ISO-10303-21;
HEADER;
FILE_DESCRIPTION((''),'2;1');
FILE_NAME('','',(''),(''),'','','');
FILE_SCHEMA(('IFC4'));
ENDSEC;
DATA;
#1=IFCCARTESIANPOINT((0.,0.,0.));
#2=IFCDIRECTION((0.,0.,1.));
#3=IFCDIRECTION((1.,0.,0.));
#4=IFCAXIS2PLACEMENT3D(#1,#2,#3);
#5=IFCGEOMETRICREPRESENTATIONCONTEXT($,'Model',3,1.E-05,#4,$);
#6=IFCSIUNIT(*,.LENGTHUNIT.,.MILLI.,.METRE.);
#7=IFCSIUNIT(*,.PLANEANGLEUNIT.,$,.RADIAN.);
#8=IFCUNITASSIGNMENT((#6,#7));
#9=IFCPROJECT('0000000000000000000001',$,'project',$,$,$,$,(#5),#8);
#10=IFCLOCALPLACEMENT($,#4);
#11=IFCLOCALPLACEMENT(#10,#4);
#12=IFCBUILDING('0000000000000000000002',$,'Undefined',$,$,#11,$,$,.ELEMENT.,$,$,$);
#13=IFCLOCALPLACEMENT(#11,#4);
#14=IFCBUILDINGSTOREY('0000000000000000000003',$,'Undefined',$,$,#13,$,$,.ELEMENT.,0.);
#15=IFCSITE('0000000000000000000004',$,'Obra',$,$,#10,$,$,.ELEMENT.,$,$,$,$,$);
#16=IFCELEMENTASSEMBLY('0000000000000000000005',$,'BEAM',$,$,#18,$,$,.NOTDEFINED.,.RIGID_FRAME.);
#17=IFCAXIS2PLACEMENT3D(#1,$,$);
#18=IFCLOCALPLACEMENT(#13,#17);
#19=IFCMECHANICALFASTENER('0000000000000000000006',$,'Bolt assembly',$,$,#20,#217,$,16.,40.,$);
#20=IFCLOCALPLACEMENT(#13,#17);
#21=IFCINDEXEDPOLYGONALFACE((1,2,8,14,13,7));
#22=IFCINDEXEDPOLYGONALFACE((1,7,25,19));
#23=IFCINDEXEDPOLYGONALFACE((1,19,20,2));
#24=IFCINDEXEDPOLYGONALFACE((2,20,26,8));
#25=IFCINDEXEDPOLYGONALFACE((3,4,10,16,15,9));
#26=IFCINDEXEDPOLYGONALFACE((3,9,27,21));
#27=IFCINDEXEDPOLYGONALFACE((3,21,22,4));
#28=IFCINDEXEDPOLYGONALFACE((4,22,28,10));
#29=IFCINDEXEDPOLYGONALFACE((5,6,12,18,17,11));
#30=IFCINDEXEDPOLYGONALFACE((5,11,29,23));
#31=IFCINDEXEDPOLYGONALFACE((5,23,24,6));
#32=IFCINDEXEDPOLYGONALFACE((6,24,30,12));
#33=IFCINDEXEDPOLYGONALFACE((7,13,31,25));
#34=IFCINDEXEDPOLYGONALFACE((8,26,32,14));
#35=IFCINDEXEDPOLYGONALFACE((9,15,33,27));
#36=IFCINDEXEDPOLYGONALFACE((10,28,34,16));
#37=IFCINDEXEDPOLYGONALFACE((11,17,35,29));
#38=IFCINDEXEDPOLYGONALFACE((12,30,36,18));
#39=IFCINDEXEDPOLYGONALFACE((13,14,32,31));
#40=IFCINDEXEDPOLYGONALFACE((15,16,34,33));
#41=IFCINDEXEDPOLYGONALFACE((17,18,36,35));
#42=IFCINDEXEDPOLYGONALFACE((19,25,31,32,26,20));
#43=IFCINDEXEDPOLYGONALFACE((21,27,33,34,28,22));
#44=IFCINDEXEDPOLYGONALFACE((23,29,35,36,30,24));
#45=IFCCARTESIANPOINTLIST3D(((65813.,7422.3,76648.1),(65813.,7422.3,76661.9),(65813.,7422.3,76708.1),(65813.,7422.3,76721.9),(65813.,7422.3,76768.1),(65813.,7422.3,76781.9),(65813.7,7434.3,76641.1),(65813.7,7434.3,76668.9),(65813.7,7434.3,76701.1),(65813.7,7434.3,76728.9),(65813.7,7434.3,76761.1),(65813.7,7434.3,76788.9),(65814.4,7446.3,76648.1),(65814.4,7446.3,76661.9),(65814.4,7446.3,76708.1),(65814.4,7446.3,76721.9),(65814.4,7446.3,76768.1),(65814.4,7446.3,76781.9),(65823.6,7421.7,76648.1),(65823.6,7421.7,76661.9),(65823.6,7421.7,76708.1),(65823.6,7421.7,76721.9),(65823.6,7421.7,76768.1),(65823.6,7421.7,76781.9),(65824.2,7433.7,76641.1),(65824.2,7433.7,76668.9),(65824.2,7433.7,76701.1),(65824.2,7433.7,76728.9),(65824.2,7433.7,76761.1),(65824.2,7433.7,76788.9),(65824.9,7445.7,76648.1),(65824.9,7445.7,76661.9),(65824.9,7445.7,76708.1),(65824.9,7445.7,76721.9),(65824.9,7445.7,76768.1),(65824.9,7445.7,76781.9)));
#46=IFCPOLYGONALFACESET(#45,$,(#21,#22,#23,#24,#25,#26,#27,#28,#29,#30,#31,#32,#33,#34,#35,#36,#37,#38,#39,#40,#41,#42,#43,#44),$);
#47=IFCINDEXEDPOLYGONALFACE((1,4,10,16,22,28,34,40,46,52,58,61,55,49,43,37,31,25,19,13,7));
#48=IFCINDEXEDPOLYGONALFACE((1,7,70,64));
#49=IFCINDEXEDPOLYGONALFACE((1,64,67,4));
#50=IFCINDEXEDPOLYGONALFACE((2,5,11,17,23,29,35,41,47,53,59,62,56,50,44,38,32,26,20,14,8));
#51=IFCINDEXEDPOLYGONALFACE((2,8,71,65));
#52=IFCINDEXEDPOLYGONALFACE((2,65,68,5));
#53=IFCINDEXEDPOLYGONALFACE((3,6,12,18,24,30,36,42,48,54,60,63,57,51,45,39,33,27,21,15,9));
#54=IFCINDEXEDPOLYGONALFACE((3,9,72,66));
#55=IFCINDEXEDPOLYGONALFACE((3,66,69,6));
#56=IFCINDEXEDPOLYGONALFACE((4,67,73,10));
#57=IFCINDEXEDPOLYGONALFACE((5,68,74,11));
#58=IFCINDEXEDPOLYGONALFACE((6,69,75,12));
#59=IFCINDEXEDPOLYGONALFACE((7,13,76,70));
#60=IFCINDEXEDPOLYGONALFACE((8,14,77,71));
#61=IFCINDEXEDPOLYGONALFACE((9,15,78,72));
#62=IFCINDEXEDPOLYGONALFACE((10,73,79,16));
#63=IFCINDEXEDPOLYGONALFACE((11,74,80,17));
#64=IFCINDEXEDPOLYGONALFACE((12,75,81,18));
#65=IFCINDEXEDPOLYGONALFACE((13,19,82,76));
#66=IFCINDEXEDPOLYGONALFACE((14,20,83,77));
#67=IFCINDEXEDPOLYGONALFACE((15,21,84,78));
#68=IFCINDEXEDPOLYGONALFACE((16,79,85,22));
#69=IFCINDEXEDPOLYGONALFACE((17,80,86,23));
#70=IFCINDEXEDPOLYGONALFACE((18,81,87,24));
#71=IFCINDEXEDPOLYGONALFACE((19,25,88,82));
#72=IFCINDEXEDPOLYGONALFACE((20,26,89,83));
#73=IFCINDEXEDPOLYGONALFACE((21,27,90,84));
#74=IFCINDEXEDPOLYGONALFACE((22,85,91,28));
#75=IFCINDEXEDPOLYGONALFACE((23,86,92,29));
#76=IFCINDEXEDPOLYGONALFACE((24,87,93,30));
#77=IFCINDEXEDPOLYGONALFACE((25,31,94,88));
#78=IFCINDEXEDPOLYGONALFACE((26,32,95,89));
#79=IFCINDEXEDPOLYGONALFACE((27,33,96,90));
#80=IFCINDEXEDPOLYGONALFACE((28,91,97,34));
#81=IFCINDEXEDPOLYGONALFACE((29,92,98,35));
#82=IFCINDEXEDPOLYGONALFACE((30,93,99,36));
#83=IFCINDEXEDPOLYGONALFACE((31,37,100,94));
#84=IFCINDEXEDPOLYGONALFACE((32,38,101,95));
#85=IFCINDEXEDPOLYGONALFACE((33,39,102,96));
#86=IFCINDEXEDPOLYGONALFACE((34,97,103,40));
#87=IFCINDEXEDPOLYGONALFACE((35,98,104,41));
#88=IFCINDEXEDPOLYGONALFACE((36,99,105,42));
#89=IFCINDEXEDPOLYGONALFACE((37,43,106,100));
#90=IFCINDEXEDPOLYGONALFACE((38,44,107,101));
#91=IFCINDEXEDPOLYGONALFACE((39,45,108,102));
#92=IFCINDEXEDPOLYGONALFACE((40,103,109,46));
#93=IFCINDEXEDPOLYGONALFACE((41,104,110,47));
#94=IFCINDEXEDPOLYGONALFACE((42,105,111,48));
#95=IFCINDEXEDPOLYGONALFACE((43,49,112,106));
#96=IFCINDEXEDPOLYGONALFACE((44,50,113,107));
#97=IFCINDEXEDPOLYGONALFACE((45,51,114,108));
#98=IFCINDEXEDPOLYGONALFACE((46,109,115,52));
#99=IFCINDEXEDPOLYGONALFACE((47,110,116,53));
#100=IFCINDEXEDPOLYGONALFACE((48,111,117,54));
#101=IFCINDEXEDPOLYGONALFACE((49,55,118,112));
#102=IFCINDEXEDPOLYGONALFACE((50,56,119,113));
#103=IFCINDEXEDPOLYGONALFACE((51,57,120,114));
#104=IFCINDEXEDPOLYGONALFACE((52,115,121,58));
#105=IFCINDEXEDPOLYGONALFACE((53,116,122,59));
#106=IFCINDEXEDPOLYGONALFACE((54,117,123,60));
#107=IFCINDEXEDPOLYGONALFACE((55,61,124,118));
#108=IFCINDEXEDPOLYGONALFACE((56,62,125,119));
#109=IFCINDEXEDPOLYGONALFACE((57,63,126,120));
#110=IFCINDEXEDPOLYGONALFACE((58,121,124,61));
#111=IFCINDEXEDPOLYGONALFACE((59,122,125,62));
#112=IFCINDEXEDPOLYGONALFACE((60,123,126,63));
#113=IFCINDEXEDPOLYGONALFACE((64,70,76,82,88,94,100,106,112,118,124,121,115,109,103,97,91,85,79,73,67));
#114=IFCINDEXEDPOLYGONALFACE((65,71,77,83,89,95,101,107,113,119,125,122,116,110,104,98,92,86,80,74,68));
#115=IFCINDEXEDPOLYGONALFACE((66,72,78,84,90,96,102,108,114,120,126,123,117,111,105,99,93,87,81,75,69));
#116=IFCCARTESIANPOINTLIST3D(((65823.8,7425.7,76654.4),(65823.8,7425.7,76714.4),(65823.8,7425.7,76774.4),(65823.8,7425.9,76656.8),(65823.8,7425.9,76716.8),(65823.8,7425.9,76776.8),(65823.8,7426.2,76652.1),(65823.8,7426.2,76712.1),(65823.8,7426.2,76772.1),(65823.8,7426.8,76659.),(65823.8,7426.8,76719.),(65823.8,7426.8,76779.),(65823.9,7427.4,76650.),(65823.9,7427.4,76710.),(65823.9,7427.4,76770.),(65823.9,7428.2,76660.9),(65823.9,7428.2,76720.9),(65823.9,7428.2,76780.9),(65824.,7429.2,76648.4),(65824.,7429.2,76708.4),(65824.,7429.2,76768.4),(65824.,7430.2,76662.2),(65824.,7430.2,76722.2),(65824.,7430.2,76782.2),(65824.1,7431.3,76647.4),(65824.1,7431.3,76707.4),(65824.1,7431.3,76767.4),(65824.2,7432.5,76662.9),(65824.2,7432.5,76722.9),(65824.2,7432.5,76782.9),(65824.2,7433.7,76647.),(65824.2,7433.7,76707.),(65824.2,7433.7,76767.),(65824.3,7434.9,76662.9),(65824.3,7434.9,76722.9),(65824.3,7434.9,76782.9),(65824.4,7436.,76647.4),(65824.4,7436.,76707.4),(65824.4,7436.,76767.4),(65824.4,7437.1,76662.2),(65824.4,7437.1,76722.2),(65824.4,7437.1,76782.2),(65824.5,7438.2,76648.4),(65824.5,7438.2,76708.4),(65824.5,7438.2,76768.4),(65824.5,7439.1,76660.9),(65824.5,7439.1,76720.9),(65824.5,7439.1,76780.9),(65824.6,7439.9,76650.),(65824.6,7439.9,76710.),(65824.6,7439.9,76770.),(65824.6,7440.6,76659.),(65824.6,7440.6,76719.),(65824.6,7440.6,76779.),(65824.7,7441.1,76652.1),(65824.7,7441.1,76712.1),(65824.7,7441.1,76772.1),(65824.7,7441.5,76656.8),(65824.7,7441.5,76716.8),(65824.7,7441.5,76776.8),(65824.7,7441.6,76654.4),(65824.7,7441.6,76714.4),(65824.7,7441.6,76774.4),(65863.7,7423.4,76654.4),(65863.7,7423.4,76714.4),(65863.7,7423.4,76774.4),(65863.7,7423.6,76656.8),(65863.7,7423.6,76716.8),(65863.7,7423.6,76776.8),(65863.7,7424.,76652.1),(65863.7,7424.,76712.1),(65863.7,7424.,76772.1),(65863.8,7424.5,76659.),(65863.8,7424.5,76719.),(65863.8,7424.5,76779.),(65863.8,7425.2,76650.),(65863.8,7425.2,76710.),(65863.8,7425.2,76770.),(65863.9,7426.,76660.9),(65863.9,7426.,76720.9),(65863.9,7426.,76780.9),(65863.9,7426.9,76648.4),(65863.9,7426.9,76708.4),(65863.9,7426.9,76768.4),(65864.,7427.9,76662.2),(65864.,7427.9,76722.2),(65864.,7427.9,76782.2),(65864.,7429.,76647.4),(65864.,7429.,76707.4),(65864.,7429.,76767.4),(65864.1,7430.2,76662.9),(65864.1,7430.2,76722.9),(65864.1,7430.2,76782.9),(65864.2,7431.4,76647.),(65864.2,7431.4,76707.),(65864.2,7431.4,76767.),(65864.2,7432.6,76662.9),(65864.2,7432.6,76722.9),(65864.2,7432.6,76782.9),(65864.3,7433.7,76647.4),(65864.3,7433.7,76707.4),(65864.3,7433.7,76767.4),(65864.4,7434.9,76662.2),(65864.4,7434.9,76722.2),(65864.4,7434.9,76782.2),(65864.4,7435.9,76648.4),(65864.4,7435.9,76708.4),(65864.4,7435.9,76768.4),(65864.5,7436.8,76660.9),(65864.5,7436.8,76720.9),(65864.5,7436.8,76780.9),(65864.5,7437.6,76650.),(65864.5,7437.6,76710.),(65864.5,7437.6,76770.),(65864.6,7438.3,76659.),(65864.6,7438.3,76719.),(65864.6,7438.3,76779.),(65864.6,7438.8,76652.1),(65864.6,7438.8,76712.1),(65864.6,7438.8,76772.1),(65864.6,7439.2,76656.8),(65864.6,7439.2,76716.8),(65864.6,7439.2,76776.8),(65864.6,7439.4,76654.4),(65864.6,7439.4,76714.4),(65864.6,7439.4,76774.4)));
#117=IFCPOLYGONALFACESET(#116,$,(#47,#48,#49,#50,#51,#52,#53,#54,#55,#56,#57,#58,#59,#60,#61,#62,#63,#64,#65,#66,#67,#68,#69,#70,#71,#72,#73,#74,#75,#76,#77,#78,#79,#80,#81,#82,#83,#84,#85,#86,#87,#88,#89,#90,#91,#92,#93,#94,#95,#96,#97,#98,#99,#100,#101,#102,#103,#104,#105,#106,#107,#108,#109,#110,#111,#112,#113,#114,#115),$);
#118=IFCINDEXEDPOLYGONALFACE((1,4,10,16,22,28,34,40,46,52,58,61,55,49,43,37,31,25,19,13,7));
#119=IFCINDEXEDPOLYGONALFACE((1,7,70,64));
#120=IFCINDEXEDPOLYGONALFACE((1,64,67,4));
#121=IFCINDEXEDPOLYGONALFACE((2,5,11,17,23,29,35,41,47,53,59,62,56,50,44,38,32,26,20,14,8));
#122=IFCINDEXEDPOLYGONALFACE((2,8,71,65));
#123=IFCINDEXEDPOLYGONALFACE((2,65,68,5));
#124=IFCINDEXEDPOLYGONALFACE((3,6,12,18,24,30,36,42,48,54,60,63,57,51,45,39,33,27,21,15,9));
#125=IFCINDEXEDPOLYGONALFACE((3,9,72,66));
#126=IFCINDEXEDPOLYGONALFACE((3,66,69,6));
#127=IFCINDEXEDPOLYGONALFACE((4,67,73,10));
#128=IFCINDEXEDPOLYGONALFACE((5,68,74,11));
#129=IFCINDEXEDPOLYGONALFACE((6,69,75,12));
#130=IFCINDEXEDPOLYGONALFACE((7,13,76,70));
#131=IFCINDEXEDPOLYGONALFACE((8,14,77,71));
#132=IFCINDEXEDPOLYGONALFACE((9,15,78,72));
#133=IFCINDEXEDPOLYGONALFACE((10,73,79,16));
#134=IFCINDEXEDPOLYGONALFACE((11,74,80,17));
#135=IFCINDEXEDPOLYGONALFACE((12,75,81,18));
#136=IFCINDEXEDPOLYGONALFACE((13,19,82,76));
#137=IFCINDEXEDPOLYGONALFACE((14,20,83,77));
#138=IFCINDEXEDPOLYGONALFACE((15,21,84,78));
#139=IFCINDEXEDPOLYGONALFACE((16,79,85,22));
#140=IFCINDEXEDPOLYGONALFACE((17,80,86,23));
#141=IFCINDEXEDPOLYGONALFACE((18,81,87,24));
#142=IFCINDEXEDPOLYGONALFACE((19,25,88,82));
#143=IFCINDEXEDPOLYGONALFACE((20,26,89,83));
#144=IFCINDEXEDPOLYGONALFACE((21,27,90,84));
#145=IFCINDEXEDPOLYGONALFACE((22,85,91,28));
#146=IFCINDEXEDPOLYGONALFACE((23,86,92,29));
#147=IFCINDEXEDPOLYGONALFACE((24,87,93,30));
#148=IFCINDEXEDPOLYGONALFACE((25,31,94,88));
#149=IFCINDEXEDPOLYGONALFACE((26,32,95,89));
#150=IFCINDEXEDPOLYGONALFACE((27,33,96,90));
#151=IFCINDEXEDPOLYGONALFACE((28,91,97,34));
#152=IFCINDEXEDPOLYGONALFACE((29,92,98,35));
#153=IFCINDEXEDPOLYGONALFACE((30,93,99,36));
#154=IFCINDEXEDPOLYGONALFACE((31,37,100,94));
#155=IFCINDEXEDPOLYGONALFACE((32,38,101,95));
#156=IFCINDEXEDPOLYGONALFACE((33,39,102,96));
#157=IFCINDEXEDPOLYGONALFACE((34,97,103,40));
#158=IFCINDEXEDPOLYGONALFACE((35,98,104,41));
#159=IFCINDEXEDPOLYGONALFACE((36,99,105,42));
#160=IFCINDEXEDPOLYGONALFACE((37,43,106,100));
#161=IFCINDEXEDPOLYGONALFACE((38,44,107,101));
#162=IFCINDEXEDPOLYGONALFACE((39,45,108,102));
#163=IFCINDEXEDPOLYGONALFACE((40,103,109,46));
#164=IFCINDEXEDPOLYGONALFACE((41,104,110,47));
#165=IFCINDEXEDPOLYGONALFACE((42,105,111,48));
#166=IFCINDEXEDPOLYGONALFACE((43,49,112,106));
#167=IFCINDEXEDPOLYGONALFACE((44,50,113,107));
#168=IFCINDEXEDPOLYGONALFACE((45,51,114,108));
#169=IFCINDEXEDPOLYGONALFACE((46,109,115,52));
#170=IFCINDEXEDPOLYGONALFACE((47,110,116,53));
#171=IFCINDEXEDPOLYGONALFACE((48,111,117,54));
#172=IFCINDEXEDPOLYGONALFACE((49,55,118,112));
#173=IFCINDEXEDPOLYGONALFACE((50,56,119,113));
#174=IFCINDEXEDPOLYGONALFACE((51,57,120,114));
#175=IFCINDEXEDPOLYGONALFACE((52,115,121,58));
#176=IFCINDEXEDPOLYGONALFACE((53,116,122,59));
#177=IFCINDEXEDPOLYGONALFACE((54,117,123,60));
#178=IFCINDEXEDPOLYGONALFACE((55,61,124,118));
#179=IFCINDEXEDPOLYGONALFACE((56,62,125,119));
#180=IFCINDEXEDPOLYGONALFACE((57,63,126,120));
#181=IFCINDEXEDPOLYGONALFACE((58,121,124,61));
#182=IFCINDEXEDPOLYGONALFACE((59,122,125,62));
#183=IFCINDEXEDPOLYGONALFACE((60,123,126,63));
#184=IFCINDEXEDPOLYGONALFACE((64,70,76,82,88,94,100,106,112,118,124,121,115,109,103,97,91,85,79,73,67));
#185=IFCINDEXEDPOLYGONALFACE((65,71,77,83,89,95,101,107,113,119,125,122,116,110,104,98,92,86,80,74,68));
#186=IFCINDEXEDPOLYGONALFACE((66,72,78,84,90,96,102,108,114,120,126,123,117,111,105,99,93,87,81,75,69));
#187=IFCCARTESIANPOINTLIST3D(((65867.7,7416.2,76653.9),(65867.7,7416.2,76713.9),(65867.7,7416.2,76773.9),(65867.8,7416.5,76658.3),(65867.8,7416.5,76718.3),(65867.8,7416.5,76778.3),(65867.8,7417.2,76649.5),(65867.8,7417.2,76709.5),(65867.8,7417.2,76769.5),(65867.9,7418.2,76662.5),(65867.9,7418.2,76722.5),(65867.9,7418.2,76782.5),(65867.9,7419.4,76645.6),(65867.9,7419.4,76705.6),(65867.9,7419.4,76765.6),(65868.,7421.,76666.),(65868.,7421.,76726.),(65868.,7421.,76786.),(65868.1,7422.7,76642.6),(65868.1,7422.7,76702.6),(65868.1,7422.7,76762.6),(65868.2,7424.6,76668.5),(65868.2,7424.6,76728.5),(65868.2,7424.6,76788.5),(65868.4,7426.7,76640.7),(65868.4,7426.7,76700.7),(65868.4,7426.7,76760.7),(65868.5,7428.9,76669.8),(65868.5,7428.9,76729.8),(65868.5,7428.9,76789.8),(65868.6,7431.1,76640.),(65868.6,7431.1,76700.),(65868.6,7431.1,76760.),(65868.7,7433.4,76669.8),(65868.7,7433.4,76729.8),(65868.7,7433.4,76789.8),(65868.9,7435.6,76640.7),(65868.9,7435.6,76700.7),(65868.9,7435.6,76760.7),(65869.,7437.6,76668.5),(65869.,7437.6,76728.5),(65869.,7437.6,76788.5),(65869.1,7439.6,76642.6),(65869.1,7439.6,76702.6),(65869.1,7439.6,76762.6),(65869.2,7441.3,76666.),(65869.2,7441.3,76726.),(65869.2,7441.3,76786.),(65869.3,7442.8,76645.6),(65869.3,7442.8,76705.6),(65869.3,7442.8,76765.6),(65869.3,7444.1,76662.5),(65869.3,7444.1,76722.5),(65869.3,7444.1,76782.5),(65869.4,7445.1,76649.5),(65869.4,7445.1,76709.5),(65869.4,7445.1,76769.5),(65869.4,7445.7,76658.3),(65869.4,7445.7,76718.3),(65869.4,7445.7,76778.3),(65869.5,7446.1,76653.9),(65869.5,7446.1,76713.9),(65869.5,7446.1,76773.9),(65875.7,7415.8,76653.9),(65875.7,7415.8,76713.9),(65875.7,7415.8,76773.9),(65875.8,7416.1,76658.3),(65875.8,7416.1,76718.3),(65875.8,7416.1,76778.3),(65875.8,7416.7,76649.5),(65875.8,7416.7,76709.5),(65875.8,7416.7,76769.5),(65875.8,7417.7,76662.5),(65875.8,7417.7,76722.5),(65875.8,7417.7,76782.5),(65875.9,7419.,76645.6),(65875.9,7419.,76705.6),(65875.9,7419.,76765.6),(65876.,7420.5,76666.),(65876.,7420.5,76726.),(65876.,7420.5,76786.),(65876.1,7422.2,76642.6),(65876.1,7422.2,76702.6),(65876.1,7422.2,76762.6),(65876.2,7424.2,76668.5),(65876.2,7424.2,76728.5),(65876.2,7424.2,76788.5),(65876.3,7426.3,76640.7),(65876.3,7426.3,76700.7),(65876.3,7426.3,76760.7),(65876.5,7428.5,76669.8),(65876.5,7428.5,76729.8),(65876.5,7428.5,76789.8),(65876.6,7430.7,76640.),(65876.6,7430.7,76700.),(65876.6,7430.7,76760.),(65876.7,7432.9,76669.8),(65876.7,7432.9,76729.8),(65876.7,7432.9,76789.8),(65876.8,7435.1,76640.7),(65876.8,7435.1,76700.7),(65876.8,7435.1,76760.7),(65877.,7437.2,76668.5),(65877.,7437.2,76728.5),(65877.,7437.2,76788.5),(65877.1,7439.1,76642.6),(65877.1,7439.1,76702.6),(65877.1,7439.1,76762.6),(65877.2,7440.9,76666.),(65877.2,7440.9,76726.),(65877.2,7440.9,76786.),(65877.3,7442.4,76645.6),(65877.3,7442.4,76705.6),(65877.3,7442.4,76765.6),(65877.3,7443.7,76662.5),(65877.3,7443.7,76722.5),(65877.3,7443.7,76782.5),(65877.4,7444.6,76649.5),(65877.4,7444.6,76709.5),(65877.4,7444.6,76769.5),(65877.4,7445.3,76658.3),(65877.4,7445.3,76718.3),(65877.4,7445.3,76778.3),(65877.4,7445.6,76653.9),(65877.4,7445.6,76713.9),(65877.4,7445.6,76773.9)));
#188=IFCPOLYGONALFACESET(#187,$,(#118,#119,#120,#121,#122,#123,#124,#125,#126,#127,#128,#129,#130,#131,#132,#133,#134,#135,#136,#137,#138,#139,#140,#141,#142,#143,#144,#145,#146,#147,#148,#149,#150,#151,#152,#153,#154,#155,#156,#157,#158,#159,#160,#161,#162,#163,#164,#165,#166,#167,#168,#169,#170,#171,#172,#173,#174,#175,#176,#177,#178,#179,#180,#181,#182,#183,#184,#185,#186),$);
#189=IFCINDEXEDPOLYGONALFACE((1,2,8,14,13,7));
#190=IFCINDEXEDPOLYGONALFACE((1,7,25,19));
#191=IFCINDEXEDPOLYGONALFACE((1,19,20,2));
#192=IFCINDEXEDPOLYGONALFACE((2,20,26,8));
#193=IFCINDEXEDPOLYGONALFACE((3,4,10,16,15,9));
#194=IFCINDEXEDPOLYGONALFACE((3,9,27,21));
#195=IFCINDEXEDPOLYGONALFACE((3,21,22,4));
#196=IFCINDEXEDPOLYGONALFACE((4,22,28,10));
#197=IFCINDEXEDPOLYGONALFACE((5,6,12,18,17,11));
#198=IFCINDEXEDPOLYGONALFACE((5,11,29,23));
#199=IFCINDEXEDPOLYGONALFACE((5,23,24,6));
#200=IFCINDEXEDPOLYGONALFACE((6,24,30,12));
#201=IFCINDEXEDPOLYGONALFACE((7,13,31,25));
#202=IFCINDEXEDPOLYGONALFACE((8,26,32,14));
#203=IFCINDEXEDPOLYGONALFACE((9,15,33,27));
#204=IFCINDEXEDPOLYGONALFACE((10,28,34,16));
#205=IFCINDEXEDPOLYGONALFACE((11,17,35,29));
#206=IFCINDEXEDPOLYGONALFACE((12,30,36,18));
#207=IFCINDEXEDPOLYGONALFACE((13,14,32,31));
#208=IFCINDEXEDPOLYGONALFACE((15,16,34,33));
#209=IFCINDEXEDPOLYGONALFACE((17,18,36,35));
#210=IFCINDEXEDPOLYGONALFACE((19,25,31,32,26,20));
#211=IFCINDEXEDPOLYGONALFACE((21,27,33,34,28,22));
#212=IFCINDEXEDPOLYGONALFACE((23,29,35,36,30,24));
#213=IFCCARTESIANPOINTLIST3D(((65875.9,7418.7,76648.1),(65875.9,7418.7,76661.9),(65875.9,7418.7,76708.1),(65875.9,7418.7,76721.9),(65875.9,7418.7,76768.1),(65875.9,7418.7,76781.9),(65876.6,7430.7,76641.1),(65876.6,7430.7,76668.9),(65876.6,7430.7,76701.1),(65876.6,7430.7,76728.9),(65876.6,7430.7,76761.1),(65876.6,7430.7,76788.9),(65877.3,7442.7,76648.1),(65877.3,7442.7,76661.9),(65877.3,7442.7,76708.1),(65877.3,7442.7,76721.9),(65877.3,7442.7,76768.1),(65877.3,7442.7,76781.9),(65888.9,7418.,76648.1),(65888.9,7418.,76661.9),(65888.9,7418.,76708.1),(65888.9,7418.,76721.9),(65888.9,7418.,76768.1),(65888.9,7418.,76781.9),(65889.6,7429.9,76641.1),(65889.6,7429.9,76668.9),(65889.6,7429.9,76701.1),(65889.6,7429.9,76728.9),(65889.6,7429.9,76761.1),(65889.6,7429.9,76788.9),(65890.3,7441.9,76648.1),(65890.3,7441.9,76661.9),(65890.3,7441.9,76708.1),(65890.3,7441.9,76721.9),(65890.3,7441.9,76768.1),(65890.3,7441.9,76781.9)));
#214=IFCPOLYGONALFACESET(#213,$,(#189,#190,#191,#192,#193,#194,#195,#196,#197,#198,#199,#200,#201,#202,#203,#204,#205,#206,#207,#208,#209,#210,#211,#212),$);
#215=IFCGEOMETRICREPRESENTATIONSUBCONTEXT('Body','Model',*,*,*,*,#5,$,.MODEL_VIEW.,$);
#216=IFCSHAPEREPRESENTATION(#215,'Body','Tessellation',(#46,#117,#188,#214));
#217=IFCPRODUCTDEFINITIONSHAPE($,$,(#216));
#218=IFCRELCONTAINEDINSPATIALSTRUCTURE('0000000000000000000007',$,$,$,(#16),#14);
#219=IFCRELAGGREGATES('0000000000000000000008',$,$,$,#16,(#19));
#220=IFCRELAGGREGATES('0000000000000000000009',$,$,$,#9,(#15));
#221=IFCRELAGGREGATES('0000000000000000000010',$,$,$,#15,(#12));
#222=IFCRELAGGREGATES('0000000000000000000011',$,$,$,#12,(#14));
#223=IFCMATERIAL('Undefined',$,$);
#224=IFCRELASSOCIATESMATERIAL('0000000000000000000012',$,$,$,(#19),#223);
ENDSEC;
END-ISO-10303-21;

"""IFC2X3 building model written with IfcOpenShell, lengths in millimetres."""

from ifc_helpers import new_model, si_unit, frame, origin_with_axes, origin_2d_with_axis, place, context, subcontext, project, spatial, polyline, circle, outline, extrude, source, transform, mapped, material, element, aggregate, save


model = new_model("IFC2X3")

# Units and contexts
model_context = context("Model", 3, precision=1e-05, world=origin_with_axes())
body_context = subcontext(model_context, "Body", "Model", "MODEL_VIEW")
ifc_project = project(units=[si_unit("LENGTHUNIT", "METRE", prefix="MILLI"), si_unit("PLANEANGLEUNIT", "RADIAN")], contexts=[model_context])

# Site, building, storey
site_placement = place(None, origin_with_axes())
site = spatial("IfcSite", under=ifc_project, at=site_placement, Name="Obra", CompositionType="ELEMENT")
building_placement = place(site_placement, origin_with_axes())
building = spatial("IfcBuilding", under=site, at=building_placement, Name="Undefined", CompositionType="ELEMENT")
storey_placement = place(building_placement, origin_with_axes())
storey = spatial("IfcBuildingStorey", under=building, at=storey_placement, Name="Undefined", CompositionType="ELEMENT", Elevation=0.0)

# Shared definitions
ifc_material_1 = material(Name="Undefined")
shared_shape_1 = source(origin_with_axes(), body_context, "Body", "SweptSolid", [
    extrude(outline(polyline([(13.9, 0.0), (6.9, 12.0), (-6.9, 12.0), (-13.9, 0.0), (-6.9, -12.0), (6.9, -12.0), (13.9, 0.0)])), frame((0.0, -19.7, 0.0), z_axis=(0.0, 1.0, 0.0), x_axis=(1.0, 0.0, 0.0)), (0.0, 0.0, 1.0), 10.6),
    extrude(circle(Radius=8.0, at=origin_2d_with_axis()), frame((0.0, -9.1, 0.0), z_axis=(0.0, 1.0, 0.0), x_axis=(1.0, 0.0, 0.0)), (0.0, 0.0, 1.0), 40.0),
    extrude(circle(Radius=15.0, at=origin_2d_with_axis()), frame((0.0, 35.3, 0.0), z_axis=(0.0, 1.0, 0.0), x_axis=(1.0, 0.0, 0.0)), (0.0, 0.0, 1.0), 8.0),
    extrude(outline(polyline([(13.9, 0.0), (6.9, 12.0), (-6.9, 12.0), (-13.9, 0.0), (-6.9, -12.0), (6.9, -12.0), (13.9, 0.0)])), frame((0.0, 43.3, 0.0), z_axis=(0.0, 1.0, 0.0), x_axis=(1.0, 0.0, 0.0)), (0.0, 0.0, 1.0), 13.0),
])

# Element assembly, mechanical fastener
assembly_1_placement = place(storey_placement, origin_with_axes())
assembly_1 = element("IfcElementAssembly", 1, at=assembly_1_placement, inside=storey, Name="BEAM", AssemblyPlace="NOTDEFINED", PredefinedType="RIGID_FRAME")
mechanical_fastener_1_placement = place(assembly_1_placement, frame((65836.2, 7483.1, 76835.0), z_axis=(-0.05711, -0.998368, 0.0), x_axis=(0.0, 0.0, -1.0)))
mechanical_fastener_1 = element("IfcMechanicalFastener", 2, at=mechanical_fastener_1_placement, material=ifc_material_1, Name="Bolt assembly", NominalDiameter=16.0, NominalLength=40.0, context=body_context, shape_type="MappedRepresentation", body=[
    mapped(shared_shape_1, transform((60.0, 0.0, 50.0))),
    mapped(shared_shape_1, transform((120.0, 0.0, 50.0))),
    mapped(shared_shape_1, transform((180.0, 0.0, 50.0))),
])
aggregate(assembly_1, [mechanical_fastener_1])

save(model, "model.ifc")
